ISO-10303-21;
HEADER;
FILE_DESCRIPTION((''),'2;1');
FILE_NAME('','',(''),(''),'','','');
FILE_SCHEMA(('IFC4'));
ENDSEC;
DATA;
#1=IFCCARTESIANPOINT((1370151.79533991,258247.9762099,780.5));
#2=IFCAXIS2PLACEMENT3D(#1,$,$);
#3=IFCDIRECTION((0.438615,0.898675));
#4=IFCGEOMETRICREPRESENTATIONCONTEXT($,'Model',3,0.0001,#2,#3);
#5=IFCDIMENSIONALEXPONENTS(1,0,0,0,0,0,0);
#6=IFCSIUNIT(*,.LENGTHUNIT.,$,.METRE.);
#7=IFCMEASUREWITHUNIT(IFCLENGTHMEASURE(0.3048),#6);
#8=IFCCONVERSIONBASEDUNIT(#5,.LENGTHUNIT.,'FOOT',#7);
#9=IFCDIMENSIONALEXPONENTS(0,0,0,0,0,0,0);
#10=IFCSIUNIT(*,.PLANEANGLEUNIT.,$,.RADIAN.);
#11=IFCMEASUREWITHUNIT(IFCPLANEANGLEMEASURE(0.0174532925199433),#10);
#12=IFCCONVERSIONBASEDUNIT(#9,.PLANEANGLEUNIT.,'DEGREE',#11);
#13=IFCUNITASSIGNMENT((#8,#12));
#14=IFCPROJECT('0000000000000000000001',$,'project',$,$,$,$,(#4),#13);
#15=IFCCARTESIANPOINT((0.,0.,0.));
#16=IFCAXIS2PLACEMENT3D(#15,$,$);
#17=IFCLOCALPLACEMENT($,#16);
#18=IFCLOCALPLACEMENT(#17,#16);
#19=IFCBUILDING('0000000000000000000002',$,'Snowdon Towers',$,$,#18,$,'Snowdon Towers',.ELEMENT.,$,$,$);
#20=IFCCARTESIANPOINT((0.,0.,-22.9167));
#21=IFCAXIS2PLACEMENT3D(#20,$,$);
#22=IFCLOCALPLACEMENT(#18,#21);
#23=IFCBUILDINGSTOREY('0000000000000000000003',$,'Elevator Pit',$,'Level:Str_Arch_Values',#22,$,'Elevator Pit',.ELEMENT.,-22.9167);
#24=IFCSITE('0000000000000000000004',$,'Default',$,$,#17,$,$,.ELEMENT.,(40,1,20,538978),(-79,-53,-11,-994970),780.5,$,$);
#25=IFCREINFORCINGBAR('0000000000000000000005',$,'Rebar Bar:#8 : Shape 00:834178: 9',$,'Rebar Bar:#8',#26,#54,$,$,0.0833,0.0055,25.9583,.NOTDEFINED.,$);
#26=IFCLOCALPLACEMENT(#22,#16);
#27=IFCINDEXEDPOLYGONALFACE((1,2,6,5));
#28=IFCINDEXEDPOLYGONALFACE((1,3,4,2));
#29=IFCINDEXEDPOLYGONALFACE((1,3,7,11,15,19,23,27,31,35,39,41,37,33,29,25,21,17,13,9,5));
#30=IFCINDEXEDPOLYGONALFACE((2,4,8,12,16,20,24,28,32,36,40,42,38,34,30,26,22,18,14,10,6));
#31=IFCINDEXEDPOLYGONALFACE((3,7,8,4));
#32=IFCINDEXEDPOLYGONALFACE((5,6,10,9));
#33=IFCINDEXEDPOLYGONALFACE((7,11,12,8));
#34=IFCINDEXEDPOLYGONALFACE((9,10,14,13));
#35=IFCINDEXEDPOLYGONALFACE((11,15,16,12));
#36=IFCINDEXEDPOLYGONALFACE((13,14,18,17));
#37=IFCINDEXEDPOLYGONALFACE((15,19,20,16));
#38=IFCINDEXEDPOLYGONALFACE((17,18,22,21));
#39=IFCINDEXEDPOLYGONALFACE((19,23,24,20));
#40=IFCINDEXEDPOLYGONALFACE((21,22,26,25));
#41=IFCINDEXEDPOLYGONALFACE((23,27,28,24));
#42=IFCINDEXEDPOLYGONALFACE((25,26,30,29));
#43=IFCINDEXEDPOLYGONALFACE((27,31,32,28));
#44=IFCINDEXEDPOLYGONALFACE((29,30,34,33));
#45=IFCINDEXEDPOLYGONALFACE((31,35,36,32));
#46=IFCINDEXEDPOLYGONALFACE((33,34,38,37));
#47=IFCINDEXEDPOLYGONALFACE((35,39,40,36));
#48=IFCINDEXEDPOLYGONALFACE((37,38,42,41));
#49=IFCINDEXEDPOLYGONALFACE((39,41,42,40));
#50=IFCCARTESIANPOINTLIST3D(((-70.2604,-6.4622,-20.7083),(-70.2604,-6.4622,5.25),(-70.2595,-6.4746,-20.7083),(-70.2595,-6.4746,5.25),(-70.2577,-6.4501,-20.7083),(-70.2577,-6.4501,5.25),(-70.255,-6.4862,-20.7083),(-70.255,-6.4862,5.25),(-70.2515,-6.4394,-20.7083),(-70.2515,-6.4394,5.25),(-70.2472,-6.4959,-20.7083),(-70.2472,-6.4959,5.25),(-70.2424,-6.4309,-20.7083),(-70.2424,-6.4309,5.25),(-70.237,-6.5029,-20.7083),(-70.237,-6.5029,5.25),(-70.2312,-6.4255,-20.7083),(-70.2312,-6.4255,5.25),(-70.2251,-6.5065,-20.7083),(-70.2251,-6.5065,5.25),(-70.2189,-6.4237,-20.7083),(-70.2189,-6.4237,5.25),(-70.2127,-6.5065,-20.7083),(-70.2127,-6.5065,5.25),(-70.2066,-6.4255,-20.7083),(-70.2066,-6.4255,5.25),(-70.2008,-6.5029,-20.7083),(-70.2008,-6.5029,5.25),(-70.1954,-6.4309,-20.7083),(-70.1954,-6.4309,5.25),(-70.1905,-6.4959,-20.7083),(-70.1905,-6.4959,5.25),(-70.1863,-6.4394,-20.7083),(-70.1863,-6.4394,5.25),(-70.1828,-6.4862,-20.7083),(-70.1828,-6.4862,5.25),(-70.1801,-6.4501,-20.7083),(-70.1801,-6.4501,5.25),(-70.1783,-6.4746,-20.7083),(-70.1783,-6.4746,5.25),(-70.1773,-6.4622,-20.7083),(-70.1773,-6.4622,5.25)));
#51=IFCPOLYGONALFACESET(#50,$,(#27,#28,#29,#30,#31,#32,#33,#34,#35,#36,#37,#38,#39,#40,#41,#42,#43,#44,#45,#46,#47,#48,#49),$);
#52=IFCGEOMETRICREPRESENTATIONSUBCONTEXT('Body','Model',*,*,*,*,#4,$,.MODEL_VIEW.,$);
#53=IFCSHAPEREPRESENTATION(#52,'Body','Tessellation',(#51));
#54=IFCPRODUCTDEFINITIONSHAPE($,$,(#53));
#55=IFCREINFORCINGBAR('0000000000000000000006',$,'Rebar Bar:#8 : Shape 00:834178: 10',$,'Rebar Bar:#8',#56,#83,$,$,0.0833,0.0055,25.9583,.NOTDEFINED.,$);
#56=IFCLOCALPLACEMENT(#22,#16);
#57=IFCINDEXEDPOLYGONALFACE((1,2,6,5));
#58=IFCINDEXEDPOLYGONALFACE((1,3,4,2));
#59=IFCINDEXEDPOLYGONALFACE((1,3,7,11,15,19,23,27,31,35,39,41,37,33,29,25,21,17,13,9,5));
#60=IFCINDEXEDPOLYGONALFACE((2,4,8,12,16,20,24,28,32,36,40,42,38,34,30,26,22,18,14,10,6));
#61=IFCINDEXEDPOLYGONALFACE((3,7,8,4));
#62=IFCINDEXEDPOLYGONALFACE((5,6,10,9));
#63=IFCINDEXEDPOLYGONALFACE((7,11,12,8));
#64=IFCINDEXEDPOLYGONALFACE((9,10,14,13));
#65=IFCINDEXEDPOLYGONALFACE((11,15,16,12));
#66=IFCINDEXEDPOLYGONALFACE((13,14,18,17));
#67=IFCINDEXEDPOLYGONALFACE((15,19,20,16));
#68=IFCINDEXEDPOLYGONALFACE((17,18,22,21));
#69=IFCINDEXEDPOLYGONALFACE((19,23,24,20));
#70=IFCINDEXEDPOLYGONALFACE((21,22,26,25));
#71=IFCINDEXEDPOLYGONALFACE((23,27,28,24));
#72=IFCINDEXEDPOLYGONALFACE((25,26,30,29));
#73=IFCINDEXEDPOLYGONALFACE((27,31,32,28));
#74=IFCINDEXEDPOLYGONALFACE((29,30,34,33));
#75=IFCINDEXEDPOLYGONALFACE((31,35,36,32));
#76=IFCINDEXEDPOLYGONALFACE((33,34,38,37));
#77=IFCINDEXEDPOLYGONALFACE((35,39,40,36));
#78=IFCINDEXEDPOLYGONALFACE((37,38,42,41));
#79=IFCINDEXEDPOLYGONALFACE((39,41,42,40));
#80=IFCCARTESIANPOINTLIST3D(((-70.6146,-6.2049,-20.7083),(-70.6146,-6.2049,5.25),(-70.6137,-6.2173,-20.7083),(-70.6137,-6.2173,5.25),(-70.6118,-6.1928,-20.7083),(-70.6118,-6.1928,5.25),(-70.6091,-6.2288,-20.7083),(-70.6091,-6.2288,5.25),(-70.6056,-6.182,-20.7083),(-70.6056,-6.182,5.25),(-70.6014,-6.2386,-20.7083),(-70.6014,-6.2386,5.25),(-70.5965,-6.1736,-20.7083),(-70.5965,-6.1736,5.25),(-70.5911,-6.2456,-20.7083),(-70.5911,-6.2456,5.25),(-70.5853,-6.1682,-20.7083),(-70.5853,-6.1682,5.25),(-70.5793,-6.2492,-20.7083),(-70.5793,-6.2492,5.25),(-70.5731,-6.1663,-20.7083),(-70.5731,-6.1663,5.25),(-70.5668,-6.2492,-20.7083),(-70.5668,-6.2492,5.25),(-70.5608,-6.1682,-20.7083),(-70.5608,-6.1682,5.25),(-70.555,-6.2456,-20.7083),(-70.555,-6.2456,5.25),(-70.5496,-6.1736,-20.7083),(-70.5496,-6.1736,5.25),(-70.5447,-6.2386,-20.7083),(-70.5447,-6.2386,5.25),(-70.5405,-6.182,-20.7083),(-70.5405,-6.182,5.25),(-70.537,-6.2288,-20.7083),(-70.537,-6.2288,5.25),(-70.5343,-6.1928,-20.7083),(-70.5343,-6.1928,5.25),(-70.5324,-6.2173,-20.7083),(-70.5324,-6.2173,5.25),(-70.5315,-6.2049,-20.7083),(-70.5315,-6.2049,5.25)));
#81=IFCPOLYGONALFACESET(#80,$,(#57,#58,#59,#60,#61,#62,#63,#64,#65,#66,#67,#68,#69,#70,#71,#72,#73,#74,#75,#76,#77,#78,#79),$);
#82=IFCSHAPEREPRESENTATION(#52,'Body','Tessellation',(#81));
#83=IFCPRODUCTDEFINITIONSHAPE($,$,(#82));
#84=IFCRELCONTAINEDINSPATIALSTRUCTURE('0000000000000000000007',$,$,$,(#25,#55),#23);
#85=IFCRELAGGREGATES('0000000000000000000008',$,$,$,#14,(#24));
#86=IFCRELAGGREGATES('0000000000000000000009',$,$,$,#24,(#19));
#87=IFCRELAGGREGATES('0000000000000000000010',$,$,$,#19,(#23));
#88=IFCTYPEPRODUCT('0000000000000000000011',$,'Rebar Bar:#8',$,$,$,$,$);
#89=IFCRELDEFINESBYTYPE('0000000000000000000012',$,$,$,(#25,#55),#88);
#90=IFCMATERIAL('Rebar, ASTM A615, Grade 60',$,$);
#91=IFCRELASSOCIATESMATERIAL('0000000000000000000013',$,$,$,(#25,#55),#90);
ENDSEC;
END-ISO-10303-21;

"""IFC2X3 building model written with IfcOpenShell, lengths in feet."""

from ifc_helpers import new_model, entity, si_unit, converted_unit, direction, frame, origin, place, context, subcontext, project, spatial, material, type_object, element, save


model = new_model("IFC2X3")

# Units and contexts
model_context = context("Model", 3, precision=0.0001, world=frame((1370151.79533991, 258247.9762099, 780.5)), true_north=direction((0.438615, 0.898675)))
body_context = subcontext(model_context, "Body", "Model", "MODEL_VIEW")
ifc_project = project(units=[converted_unit("LENGTHUNIT", "FOOT", entity("IfcLengthMeasure", 0.3048), si_unit("LENGTHUNIT", "METRE"), dimensions=[1, 0, 0, 0, 0, 0, 0]), converted_unit("PLANEANGLEUNIT", "DEGREE", entity("IfcPlaneAngleMeasure", 0.0174532925199433), si_unit("PLANEANGLEUNIT", "RADIAN"), dimensions=[0, 0, 0, 0, 0, 0, 0])], contexts=[model_context])

# Site, building, storey
site_placement = place(None, origin())
site = spatial("IfcSite", under=ifc_project, at=site_placement, Name="Default", CompositionType="ELEMENT", RefLatitude=(40, 1, 20, 538978), RefLongitude=(-79, -53, -11, -994970), RefElevation=780.5)
building_placement = place(site_placement, origin())
building = spatial("IfcBuilding", under=site, at=building_placement, Name="Snowdon Towers", LongName="Snowdon Towers", CompositionType="ELEMENT")
storey_placement = place(building_placement, frame((0.0, 0.0, -22.9167)))
storey = spatial("IfcBuildingStorey", under=building, at=storey_placement, Name="Elevator Pit", ObjectType="Level:Str_Arch_Values", LongName="Elevator Pit", CompositionType="ELEMENT", Elevation=-22.9167)

# Reinforcing bars
ifc_material = material(Name="Rebar, ASTM A615, Grade 60")
type_product_1 = type_object("IfcTypeProduct", Name="Rebar Bar:#8")
reinforcing_bar_1_placement = place(storey_placement, origin())
element("IfcReinforcingBar", 1, at=reinforcing_bar_1_placement, inside=storey, type_object=type_product_1, material=ifc_material, Name="Rebar Bar:#8 : Shape 00:834178: 9", ObjectType="Rebar Bar:#8", BarLength=25.9583, BarRole="NOTDEFINED", CrossSectionArea=0.0055, NominalDiameter=0.0833, context=body_context, shape_type="AdvancedSweptSolid", body=[
    entity("IfcSweptDiskSolid", entity("IfcCompositeCurve", [entity("IfcCompositeCurveSegment", "CONTINUOUS", True, entity("IfcPolyline", [entity("IfcCartesianPoint", [-70.2189, -6.4653, -20.7083]), entity("IfcCartesianPoint", [-70.2189, -6.4653, 5.25])]))], False), 0.0417, None, 0.0, 1.0),
])
reinforcing_bar_2_placement = place(storey_placement, origin())
element("IfcReinforcingBar", 2, at=reinforcing_bar_2_placement, inside=storey, type_object=type_product_1, material=ifc_material, Name="Rebar Bar:#8 : Shape 00:834178: 10", ObjectType="Rebar Bar:#8", BarLength=25.9583, BarRole="NOTDEFINED", CrossSectionArea=0.0055, NominalDiameter=0.0833, context=body_context, shape_type="AdvancedSweptSolid", body=[
    entity("IfcSweptDiskSolid", entity("IfcCompositeCurve", [entity("IfcCompositeCurveSegment", "CONTINUOUS", True, entity("IfcPolyline", [entity("IfcCartesianPoint", [-70.5731, -6.208, -20.7083]), entity("IfcCartesianPoint", [-70.5731, -6.208, 5.25])]))], False), 0.0417, None, 0.0, 1.0),
])

save(model, "model.ifc")
